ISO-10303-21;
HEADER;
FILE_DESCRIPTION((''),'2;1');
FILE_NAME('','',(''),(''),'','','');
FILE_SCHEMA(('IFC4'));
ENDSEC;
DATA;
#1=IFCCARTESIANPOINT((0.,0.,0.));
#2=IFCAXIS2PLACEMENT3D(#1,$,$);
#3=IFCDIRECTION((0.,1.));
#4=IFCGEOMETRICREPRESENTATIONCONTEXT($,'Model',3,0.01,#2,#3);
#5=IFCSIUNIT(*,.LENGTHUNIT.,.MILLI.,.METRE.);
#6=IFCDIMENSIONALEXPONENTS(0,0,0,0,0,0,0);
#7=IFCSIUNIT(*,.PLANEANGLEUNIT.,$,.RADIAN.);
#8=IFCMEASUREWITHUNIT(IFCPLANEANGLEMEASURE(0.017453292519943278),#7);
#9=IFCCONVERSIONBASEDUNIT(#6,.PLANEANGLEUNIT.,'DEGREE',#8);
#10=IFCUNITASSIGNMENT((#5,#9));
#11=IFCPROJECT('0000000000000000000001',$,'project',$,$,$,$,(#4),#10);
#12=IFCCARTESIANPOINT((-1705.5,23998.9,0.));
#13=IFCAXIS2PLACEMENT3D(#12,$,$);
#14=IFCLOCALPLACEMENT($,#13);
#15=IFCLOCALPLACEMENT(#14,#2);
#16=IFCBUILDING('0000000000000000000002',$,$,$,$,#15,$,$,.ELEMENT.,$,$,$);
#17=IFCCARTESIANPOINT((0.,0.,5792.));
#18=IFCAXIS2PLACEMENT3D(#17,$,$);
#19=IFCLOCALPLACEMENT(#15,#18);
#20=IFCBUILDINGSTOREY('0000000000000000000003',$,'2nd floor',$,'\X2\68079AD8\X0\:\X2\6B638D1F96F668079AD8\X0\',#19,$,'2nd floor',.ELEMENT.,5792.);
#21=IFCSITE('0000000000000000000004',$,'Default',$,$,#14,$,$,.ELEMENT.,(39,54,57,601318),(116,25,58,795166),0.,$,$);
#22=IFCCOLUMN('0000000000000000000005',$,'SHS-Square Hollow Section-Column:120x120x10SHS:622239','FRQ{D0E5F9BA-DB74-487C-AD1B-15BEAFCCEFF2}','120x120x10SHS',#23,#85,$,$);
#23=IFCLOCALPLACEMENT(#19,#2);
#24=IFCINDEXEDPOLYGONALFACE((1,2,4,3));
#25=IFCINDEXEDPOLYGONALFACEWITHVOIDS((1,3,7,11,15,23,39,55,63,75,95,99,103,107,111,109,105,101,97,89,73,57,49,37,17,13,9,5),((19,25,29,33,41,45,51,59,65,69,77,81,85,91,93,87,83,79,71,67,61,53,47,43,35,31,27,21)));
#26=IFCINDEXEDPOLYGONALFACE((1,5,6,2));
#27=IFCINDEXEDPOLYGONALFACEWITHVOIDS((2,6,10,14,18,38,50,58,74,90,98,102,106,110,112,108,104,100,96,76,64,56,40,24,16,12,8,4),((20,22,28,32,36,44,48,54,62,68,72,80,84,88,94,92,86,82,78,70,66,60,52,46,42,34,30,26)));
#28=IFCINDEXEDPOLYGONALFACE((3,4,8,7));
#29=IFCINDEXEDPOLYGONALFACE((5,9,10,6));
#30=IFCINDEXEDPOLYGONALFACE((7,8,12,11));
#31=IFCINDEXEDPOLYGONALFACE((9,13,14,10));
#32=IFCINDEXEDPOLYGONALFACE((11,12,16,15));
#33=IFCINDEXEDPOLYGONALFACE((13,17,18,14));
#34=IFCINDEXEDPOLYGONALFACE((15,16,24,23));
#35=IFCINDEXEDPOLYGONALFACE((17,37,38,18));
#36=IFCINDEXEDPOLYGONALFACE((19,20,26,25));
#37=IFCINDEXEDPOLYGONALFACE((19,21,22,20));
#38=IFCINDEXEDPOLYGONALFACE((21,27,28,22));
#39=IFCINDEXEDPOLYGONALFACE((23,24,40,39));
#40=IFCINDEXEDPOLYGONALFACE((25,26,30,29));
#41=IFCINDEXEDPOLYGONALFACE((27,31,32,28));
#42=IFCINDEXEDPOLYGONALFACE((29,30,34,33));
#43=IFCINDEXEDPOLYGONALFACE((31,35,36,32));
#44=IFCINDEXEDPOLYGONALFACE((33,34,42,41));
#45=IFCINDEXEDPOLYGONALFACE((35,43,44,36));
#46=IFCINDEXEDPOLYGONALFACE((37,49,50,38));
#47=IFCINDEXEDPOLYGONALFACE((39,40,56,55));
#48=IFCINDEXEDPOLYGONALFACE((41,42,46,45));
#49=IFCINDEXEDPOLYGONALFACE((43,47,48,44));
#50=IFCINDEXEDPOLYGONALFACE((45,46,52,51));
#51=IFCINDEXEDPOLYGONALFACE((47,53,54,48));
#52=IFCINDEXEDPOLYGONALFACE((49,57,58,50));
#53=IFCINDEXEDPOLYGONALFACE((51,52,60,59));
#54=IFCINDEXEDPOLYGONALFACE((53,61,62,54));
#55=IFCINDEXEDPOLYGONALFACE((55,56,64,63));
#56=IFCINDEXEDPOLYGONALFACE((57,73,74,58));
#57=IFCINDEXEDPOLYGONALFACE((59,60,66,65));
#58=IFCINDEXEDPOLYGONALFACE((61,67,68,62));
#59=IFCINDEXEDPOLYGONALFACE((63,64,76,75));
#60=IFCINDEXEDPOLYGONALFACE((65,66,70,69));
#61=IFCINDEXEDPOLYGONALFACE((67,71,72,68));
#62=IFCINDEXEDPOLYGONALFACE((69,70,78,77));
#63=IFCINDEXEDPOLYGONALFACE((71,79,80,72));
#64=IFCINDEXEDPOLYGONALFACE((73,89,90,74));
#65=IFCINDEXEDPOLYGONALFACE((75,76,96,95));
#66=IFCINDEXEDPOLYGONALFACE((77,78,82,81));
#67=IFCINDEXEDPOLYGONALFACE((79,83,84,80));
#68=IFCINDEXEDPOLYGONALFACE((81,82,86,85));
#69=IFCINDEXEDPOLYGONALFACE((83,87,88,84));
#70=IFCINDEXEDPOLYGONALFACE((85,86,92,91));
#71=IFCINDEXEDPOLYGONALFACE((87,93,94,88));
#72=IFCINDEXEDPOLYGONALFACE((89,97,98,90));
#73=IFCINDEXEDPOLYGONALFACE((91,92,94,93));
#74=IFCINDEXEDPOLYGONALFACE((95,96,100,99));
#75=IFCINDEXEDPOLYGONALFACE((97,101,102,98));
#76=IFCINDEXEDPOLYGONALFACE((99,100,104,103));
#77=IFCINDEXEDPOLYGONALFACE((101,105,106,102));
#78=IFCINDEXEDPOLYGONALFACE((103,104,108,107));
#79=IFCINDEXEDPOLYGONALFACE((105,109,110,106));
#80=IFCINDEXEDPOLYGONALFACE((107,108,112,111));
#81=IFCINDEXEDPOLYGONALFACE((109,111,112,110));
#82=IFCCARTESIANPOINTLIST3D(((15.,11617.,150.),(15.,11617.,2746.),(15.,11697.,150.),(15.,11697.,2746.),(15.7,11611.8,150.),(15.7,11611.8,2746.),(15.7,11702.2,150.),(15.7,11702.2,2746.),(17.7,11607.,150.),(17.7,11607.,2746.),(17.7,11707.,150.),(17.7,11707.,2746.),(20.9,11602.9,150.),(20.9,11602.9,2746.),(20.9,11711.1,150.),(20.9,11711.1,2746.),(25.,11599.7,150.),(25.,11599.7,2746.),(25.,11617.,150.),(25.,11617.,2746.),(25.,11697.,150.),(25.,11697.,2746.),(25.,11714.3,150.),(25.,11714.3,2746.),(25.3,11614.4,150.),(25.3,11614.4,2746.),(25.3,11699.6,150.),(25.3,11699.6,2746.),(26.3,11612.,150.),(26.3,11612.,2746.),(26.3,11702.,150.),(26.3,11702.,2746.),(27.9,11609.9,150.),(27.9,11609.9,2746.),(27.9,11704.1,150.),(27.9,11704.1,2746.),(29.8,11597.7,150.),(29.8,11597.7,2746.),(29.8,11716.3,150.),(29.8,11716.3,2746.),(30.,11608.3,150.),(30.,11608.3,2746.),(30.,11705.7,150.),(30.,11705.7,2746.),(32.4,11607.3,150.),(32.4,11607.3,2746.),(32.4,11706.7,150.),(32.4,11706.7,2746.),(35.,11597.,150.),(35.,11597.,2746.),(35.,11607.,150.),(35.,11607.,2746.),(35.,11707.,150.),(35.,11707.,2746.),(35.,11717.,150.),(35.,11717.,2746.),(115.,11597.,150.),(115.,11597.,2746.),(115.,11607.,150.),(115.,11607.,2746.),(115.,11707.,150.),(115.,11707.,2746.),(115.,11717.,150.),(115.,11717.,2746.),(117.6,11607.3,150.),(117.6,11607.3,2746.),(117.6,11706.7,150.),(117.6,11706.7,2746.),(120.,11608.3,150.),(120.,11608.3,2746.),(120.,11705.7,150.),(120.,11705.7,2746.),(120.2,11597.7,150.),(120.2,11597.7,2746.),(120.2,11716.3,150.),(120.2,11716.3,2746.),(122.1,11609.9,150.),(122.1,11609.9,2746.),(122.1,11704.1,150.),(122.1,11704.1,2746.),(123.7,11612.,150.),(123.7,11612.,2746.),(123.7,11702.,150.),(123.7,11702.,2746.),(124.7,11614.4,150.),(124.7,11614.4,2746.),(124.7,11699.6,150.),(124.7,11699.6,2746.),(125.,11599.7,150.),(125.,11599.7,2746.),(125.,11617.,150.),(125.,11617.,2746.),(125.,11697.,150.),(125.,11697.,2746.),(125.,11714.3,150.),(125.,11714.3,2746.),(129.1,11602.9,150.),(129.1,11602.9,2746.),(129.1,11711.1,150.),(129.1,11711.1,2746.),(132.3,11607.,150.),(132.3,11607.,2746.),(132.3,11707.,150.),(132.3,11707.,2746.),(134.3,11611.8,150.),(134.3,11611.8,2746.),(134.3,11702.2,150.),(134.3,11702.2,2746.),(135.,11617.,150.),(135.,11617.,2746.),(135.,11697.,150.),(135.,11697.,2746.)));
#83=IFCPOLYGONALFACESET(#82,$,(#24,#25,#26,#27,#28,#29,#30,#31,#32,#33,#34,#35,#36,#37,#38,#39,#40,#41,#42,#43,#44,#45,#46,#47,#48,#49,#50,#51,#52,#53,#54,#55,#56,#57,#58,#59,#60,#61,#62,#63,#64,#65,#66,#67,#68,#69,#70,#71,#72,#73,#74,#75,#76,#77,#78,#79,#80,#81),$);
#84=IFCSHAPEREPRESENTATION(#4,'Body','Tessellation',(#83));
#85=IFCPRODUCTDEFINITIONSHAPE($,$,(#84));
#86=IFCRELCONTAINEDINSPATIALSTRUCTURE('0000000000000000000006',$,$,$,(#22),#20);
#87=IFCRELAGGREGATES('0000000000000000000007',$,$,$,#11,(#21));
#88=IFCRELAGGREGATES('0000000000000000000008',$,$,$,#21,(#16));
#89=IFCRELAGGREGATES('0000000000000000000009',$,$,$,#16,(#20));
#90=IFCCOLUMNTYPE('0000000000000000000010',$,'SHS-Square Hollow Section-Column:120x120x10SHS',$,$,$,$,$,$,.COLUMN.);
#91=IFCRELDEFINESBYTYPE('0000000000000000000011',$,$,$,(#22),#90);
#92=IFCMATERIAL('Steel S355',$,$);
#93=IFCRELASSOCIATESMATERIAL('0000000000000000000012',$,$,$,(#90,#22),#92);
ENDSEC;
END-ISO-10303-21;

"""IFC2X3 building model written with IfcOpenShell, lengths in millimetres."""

from ifc_helpers import new_model, entity, si_unit, converted_unit, direction, frame, origin, origin_2d, place, context, project, spatial, hollow_rectangle, extrude, clip, halfspace, material, type_object, element, save


model = new_model("IFC2X3")

# Units and contexts
model_context = context("Model", 3, precision=0.01, world=origin(), true_north=direction((0.0, 1.0)))
ifc_project = project(units=[si_unit("LENGTHUNIT", "METRE", prefix="MILLI"), converted_unit("PLANEANGLEUNIT", "DEGREE", entity("IfcPlaneAngleMeasure", 0.017453292519943278), si_unit("PLANEANGLEUNIT", "RADIAN"), dimensions=[0, 0, 0, 0, 0, 0, 0])], contexts=[model_context])

# Site, building, storey
site_placement = place(None, frame((-1705.5, 23998.9, 0.0)))
site = spatial("IfcSite", under=ifc_project, at=site_placement, Name="Default", CompositionType="ELEMENT", RefLatitude=(39, 54, 57, 601318), RefLongitude=(116, 25, 58, 795166), RefElevation=0.0)
building_placement = place(site_placement, origin())
building = spatial("IfcBuilding", under=site, at=building_placement, CompositionType="ELEMENT")
storey_placement = place(building_placement, frame((0.0, 0.0, 5792.0)))
storey = spatial("IfcBuildingStorey", under=building, at=storey_placement, Name="2nd floor", ObjectType="标高:正负零标高", LongName="2nd floor", CompositionType="ELEMENT", Elevation=5792.0)

# Shared definitions
ifc_material_1 = material(Name="Steel S355")

# Column
column_type_1 = type_object("IfcColumnType", Name="SHS-Square Hollow Section-Column:120x120x10SHS", PredefinedType="COLUMN", material=ifc_material_1)
column_1_placement = place(storey_placement, frame((75.0, 11657.0, 2830.9), z_axis=(0.0, 0.0, 1.0), x_axis=(0.0, -1.0, 0.0)))
element("IfcColumn", 1, at=column_1_placement, inside=storey, type_object=column_type_1, material=ifc_material_1, Name="SHS-Square Hollow Section-Column:120x120x10SHS:622239", Description="FRQ{D0E5F9BA-DB74-487C-AD1B-15BEAFCCEFF2}", ObjectType="120x120x10SHS", context=model_context, shape_type="Clipping", body=[
    clip(clip(extrude(hollow_rectangle(XDim=120.0, YDim=120.0, WallThickness=10.0, InnerFilletRadius=10.0, OuterFilletRadius=20.0, at=origin_2d()), origin(), (0.0, 0.0, -1.0), 2765.7), halfspace(frame((11657.0, -75.0, -84.9), z_axis=(0.0, 0.0, -1.0), x_axis=(0.0, -1.0, 0.0)), True)), halfspace(frame((11657.0, -75.0, -2680.9), z_axis=(0.0, 0.0, 1.0), x_axis=(0.0, 1.0, 0.0)), True)),
])

save(model, "model.ifc")
